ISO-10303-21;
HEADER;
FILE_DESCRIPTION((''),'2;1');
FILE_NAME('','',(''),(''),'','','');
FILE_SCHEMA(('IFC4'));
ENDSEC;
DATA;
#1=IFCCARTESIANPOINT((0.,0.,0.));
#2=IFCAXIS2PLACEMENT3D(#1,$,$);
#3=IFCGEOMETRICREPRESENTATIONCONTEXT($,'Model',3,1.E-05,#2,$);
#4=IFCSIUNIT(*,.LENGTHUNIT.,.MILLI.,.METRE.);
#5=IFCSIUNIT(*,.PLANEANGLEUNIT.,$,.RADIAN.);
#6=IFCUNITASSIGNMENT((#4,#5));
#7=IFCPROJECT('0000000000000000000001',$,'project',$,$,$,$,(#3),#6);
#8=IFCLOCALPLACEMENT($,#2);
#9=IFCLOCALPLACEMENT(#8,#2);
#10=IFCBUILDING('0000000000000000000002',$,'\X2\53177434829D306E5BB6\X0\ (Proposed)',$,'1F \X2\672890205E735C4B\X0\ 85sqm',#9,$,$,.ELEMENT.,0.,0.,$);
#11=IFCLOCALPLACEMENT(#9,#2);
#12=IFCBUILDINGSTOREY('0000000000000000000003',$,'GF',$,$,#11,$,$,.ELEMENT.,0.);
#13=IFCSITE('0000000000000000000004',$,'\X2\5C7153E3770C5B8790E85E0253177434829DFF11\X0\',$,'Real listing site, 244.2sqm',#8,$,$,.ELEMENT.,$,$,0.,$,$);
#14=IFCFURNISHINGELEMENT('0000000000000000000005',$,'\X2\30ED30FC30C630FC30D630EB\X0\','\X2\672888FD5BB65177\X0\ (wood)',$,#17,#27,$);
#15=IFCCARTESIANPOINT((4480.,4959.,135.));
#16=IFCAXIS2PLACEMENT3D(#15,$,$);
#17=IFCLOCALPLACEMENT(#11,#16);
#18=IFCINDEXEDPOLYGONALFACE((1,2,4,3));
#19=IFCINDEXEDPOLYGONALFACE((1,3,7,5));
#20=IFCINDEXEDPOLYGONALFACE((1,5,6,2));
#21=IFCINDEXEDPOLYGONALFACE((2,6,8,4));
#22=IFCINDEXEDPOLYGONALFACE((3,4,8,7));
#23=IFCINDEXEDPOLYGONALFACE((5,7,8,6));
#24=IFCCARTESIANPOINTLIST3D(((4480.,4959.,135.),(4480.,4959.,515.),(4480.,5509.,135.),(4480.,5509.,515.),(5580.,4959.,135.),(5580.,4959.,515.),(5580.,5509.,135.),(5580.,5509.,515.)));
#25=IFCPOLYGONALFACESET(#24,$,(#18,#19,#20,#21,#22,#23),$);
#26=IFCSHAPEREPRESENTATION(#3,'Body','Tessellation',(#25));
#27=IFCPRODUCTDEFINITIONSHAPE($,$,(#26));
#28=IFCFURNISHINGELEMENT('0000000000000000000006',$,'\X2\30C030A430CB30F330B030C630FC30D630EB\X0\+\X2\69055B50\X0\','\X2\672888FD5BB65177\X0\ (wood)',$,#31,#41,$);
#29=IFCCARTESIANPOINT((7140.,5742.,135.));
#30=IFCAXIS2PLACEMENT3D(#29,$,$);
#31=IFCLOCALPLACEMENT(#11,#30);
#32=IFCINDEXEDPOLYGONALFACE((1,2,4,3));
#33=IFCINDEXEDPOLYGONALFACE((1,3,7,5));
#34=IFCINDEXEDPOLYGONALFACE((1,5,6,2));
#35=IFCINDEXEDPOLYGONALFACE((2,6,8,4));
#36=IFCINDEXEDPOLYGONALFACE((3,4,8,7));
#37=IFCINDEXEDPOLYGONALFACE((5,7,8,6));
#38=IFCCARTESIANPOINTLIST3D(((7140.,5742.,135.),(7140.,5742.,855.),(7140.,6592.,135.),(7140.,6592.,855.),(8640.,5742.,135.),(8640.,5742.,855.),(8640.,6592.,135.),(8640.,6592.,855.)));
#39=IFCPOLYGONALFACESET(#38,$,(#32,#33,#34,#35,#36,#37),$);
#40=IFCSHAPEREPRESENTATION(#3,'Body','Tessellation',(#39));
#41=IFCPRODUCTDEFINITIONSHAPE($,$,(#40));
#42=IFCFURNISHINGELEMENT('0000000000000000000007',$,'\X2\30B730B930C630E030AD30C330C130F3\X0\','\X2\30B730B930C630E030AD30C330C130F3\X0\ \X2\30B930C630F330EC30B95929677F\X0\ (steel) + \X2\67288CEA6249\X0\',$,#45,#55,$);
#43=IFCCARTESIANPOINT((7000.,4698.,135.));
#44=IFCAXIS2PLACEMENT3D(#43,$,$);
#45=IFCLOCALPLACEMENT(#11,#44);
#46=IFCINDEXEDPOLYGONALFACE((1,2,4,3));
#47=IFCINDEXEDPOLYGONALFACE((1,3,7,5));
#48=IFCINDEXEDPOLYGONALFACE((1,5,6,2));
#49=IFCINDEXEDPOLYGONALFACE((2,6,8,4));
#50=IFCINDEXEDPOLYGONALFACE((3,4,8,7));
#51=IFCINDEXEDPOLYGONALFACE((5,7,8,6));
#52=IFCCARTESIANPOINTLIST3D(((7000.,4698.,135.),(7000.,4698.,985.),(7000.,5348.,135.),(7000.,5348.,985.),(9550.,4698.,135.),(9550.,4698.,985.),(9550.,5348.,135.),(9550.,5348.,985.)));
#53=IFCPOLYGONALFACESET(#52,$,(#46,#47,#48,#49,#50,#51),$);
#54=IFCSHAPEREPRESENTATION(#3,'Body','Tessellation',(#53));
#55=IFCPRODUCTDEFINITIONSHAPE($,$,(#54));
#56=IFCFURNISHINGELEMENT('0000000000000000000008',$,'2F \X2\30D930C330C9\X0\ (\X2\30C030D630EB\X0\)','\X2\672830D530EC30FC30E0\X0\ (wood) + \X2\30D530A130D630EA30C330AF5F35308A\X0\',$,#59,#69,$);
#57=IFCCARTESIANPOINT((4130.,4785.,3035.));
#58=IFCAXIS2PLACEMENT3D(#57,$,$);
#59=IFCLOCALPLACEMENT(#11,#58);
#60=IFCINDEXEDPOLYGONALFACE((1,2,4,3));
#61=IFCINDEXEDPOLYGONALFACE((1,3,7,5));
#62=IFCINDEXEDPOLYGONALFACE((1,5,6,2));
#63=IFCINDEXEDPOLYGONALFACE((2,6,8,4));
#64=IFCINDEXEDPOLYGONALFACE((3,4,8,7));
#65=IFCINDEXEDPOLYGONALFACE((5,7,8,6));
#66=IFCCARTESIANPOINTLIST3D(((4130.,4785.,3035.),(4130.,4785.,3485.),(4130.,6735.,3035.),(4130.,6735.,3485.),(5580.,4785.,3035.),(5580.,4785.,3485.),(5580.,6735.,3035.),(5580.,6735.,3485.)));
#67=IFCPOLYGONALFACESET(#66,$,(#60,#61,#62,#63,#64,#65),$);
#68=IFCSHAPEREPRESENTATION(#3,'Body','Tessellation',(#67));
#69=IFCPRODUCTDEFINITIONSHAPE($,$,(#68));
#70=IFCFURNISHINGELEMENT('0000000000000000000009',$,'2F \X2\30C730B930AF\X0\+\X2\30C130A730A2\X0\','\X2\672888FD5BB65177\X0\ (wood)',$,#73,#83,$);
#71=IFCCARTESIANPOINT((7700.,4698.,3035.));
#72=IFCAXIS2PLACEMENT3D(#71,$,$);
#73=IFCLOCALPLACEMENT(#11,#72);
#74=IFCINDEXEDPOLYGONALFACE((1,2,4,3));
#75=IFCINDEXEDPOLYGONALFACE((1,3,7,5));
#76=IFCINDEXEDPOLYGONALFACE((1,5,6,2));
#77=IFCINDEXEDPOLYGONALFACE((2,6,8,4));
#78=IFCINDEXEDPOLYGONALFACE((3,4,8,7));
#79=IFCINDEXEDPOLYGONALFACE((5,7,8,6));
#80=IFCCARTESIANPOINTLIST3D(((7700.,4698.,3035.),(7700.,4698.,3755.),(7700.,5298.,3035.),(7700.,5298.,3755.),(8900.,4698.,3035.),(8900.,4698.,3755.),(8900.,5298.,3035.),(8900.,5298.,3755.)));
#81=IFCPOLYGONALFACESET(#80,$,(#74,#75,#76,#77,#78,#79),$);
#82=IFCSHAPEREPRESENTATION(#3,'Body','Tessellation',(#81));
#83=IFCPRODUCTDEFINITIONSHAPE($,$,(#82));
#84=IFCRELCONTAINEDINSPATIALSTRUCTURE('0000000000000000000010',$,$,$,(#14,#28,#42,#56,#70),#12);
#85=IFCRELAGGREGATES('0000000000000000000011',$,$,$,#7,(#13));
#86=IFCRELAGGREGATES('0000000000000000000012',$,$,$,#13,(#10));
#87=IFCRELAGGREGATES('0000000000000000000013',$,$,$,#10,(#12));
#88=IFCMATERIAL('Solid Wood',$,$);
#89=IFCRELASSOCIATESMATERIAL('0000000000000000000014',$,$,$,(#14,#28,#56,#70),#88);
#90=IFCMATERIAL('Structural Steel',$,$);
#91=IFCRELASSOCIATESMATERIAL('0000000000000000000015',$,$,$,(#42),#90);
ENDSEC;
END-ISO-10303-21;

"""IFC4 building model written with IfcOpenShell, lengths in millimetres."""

from ifc_helpers import new_model, si_unit, frame, frame_2d, origin, place, context, project, spatial, rectangle, extrude, material, element, save


model = new_model("IFC4")

# Units and contexts
model_context = context("Model", 3, precision=1e-05, world=origin())
ifc_project = project(units=[si_unit("LENGTHUNIT", "METRE", prefix="MILLI"), si_unit("PLANEANGLEUNIT", "RADIAN")], contexts=[model_context])

# Site, building, storey
site_placement = place(None, origin())
site = spatial("IfcSite", under=ifc_project, at=site_placement, Name="山口県宇部市北琴芝１", ObjectType="Real listing site, 244.2sqm", CompositionType="ELEMENT", RefElevation=0.0)
building_placement = place(site_placement, origin())
building = spatial("IfcBuilding", under=site, at=building_placement, Name="北琴芝の家 (Proposed)", ObjectType="1F 木造平屋 85sqm", CompositionType="ELEMENT", ElevationOfRefHeight=0.0, ElevationOfTerrain=0.0)
storey_placement = place(building_placement, origin())
storey = spatial("IfcBuildingStorey", under=building, at=storey_placement, Name="GF", CompositionType="ELEMENT", Elevation=0.0)

# Shared definitions
ifc_material_1 = material(Name="Solid Wood")

# Shared definitions
ifc_material_2 = material(Name="Structural Steel")

# Furnishing elements
furnishing_1_placement = place(storey_placement, frame((4480.0, 4959.0, 135.0)))
element("IfcFurnishingElement", 1, at=furnishing_1_placement, inside=storey, material=ifc_material_1, Name="ローテーブル", Description="木製家具 (wood)", context=model_context, shape_type="SweptSolid", body=[
    extrude(rectangle(XDim=1100.0, YDim=550.0, at=frame_2d((550.0, 275.0))), frame((4480.0, 4959.0, 135.0)), (0.0, 0.0, 1.0), 380.0),
])
furnishing_2_placement = place(storey_placement, frame((7140.0, 5742.0, 135.0)))
element("IfcFurnishingElement", 2, at=furnishing_2_placement, inside=storey, material=ifc_material_1, Name="ダイニングテーブル+椅子", Description="木製家具 (wood)", context=model_context, shape_type="SweptSolid", body=[
    extrude(rectangle(XDim=1500.0, YDim=850.0, at=frame_2d((750.0, 425.0))), frame((7140.0, 5742.0, 135.0)), (0.0, 0.0, 1.0), 720.0),
])
furnishing_3_placement = place(storey_placement, frame((7000.0, 4698.0, 135.0)))
element("IfcFurnishingElement", 3, at=furnishing_3_placement, inside=storey, material=ifc_material_2, Name="システムキッチン", Description="システムキッチン ステンレス天板 (steel) + 木質扉", context=model_context, shape_type="SweptSolid", body=[
    extrude(rectangle(XDim=2550.0, YDim=650.0, at=frame_2d((1275.0, 325.0))), frame((7000.0, 4698.0, 135.0)), (0.0, 0.0, 1.0), 850.0),
])
furnishing_4_placement = place(storey_placement, frame((4130.0, 4785.0, 3035.0)))
element("IfcFurnishingElement", 4, at=furnishing_4_placement, inside=storey, material=ifc_material_1, Name="2F ベッド (ダブル)", Description="木フレーム (wood) + ファブリック張り", context=model_context, shape_type="SweptSolid", body=[
    extrude(rectangle(XDim=1450.0, YDim=1950.0, at=frame_2d((725.0, 975.0))), frame((4130.0, 4785.0, 3035.0)), (0.0, 0.0, 1.0), 450.0),
])
furnishing_5_placement = place(storey_placement, frame((7700.0, 4698.0, 3035.0)))
element("IfcFurnishingElement", 5, at=furnishing_5_placement, inside=storey, material=ifc_material_1, Name="2F デスク+チェア", Description="木製家具 (wood)", context=model_context, shape_type="SweptSolid", body=[
    extrude(rectangle(XDim=1200.0, YDim=600.0, at=frame_2d((600.0, 300.0))), frame((7700.0, 4698.0, 3035.0)), (0.0, 0.0, 1.0), 720.0),
])

save(model, "model.ifc")
